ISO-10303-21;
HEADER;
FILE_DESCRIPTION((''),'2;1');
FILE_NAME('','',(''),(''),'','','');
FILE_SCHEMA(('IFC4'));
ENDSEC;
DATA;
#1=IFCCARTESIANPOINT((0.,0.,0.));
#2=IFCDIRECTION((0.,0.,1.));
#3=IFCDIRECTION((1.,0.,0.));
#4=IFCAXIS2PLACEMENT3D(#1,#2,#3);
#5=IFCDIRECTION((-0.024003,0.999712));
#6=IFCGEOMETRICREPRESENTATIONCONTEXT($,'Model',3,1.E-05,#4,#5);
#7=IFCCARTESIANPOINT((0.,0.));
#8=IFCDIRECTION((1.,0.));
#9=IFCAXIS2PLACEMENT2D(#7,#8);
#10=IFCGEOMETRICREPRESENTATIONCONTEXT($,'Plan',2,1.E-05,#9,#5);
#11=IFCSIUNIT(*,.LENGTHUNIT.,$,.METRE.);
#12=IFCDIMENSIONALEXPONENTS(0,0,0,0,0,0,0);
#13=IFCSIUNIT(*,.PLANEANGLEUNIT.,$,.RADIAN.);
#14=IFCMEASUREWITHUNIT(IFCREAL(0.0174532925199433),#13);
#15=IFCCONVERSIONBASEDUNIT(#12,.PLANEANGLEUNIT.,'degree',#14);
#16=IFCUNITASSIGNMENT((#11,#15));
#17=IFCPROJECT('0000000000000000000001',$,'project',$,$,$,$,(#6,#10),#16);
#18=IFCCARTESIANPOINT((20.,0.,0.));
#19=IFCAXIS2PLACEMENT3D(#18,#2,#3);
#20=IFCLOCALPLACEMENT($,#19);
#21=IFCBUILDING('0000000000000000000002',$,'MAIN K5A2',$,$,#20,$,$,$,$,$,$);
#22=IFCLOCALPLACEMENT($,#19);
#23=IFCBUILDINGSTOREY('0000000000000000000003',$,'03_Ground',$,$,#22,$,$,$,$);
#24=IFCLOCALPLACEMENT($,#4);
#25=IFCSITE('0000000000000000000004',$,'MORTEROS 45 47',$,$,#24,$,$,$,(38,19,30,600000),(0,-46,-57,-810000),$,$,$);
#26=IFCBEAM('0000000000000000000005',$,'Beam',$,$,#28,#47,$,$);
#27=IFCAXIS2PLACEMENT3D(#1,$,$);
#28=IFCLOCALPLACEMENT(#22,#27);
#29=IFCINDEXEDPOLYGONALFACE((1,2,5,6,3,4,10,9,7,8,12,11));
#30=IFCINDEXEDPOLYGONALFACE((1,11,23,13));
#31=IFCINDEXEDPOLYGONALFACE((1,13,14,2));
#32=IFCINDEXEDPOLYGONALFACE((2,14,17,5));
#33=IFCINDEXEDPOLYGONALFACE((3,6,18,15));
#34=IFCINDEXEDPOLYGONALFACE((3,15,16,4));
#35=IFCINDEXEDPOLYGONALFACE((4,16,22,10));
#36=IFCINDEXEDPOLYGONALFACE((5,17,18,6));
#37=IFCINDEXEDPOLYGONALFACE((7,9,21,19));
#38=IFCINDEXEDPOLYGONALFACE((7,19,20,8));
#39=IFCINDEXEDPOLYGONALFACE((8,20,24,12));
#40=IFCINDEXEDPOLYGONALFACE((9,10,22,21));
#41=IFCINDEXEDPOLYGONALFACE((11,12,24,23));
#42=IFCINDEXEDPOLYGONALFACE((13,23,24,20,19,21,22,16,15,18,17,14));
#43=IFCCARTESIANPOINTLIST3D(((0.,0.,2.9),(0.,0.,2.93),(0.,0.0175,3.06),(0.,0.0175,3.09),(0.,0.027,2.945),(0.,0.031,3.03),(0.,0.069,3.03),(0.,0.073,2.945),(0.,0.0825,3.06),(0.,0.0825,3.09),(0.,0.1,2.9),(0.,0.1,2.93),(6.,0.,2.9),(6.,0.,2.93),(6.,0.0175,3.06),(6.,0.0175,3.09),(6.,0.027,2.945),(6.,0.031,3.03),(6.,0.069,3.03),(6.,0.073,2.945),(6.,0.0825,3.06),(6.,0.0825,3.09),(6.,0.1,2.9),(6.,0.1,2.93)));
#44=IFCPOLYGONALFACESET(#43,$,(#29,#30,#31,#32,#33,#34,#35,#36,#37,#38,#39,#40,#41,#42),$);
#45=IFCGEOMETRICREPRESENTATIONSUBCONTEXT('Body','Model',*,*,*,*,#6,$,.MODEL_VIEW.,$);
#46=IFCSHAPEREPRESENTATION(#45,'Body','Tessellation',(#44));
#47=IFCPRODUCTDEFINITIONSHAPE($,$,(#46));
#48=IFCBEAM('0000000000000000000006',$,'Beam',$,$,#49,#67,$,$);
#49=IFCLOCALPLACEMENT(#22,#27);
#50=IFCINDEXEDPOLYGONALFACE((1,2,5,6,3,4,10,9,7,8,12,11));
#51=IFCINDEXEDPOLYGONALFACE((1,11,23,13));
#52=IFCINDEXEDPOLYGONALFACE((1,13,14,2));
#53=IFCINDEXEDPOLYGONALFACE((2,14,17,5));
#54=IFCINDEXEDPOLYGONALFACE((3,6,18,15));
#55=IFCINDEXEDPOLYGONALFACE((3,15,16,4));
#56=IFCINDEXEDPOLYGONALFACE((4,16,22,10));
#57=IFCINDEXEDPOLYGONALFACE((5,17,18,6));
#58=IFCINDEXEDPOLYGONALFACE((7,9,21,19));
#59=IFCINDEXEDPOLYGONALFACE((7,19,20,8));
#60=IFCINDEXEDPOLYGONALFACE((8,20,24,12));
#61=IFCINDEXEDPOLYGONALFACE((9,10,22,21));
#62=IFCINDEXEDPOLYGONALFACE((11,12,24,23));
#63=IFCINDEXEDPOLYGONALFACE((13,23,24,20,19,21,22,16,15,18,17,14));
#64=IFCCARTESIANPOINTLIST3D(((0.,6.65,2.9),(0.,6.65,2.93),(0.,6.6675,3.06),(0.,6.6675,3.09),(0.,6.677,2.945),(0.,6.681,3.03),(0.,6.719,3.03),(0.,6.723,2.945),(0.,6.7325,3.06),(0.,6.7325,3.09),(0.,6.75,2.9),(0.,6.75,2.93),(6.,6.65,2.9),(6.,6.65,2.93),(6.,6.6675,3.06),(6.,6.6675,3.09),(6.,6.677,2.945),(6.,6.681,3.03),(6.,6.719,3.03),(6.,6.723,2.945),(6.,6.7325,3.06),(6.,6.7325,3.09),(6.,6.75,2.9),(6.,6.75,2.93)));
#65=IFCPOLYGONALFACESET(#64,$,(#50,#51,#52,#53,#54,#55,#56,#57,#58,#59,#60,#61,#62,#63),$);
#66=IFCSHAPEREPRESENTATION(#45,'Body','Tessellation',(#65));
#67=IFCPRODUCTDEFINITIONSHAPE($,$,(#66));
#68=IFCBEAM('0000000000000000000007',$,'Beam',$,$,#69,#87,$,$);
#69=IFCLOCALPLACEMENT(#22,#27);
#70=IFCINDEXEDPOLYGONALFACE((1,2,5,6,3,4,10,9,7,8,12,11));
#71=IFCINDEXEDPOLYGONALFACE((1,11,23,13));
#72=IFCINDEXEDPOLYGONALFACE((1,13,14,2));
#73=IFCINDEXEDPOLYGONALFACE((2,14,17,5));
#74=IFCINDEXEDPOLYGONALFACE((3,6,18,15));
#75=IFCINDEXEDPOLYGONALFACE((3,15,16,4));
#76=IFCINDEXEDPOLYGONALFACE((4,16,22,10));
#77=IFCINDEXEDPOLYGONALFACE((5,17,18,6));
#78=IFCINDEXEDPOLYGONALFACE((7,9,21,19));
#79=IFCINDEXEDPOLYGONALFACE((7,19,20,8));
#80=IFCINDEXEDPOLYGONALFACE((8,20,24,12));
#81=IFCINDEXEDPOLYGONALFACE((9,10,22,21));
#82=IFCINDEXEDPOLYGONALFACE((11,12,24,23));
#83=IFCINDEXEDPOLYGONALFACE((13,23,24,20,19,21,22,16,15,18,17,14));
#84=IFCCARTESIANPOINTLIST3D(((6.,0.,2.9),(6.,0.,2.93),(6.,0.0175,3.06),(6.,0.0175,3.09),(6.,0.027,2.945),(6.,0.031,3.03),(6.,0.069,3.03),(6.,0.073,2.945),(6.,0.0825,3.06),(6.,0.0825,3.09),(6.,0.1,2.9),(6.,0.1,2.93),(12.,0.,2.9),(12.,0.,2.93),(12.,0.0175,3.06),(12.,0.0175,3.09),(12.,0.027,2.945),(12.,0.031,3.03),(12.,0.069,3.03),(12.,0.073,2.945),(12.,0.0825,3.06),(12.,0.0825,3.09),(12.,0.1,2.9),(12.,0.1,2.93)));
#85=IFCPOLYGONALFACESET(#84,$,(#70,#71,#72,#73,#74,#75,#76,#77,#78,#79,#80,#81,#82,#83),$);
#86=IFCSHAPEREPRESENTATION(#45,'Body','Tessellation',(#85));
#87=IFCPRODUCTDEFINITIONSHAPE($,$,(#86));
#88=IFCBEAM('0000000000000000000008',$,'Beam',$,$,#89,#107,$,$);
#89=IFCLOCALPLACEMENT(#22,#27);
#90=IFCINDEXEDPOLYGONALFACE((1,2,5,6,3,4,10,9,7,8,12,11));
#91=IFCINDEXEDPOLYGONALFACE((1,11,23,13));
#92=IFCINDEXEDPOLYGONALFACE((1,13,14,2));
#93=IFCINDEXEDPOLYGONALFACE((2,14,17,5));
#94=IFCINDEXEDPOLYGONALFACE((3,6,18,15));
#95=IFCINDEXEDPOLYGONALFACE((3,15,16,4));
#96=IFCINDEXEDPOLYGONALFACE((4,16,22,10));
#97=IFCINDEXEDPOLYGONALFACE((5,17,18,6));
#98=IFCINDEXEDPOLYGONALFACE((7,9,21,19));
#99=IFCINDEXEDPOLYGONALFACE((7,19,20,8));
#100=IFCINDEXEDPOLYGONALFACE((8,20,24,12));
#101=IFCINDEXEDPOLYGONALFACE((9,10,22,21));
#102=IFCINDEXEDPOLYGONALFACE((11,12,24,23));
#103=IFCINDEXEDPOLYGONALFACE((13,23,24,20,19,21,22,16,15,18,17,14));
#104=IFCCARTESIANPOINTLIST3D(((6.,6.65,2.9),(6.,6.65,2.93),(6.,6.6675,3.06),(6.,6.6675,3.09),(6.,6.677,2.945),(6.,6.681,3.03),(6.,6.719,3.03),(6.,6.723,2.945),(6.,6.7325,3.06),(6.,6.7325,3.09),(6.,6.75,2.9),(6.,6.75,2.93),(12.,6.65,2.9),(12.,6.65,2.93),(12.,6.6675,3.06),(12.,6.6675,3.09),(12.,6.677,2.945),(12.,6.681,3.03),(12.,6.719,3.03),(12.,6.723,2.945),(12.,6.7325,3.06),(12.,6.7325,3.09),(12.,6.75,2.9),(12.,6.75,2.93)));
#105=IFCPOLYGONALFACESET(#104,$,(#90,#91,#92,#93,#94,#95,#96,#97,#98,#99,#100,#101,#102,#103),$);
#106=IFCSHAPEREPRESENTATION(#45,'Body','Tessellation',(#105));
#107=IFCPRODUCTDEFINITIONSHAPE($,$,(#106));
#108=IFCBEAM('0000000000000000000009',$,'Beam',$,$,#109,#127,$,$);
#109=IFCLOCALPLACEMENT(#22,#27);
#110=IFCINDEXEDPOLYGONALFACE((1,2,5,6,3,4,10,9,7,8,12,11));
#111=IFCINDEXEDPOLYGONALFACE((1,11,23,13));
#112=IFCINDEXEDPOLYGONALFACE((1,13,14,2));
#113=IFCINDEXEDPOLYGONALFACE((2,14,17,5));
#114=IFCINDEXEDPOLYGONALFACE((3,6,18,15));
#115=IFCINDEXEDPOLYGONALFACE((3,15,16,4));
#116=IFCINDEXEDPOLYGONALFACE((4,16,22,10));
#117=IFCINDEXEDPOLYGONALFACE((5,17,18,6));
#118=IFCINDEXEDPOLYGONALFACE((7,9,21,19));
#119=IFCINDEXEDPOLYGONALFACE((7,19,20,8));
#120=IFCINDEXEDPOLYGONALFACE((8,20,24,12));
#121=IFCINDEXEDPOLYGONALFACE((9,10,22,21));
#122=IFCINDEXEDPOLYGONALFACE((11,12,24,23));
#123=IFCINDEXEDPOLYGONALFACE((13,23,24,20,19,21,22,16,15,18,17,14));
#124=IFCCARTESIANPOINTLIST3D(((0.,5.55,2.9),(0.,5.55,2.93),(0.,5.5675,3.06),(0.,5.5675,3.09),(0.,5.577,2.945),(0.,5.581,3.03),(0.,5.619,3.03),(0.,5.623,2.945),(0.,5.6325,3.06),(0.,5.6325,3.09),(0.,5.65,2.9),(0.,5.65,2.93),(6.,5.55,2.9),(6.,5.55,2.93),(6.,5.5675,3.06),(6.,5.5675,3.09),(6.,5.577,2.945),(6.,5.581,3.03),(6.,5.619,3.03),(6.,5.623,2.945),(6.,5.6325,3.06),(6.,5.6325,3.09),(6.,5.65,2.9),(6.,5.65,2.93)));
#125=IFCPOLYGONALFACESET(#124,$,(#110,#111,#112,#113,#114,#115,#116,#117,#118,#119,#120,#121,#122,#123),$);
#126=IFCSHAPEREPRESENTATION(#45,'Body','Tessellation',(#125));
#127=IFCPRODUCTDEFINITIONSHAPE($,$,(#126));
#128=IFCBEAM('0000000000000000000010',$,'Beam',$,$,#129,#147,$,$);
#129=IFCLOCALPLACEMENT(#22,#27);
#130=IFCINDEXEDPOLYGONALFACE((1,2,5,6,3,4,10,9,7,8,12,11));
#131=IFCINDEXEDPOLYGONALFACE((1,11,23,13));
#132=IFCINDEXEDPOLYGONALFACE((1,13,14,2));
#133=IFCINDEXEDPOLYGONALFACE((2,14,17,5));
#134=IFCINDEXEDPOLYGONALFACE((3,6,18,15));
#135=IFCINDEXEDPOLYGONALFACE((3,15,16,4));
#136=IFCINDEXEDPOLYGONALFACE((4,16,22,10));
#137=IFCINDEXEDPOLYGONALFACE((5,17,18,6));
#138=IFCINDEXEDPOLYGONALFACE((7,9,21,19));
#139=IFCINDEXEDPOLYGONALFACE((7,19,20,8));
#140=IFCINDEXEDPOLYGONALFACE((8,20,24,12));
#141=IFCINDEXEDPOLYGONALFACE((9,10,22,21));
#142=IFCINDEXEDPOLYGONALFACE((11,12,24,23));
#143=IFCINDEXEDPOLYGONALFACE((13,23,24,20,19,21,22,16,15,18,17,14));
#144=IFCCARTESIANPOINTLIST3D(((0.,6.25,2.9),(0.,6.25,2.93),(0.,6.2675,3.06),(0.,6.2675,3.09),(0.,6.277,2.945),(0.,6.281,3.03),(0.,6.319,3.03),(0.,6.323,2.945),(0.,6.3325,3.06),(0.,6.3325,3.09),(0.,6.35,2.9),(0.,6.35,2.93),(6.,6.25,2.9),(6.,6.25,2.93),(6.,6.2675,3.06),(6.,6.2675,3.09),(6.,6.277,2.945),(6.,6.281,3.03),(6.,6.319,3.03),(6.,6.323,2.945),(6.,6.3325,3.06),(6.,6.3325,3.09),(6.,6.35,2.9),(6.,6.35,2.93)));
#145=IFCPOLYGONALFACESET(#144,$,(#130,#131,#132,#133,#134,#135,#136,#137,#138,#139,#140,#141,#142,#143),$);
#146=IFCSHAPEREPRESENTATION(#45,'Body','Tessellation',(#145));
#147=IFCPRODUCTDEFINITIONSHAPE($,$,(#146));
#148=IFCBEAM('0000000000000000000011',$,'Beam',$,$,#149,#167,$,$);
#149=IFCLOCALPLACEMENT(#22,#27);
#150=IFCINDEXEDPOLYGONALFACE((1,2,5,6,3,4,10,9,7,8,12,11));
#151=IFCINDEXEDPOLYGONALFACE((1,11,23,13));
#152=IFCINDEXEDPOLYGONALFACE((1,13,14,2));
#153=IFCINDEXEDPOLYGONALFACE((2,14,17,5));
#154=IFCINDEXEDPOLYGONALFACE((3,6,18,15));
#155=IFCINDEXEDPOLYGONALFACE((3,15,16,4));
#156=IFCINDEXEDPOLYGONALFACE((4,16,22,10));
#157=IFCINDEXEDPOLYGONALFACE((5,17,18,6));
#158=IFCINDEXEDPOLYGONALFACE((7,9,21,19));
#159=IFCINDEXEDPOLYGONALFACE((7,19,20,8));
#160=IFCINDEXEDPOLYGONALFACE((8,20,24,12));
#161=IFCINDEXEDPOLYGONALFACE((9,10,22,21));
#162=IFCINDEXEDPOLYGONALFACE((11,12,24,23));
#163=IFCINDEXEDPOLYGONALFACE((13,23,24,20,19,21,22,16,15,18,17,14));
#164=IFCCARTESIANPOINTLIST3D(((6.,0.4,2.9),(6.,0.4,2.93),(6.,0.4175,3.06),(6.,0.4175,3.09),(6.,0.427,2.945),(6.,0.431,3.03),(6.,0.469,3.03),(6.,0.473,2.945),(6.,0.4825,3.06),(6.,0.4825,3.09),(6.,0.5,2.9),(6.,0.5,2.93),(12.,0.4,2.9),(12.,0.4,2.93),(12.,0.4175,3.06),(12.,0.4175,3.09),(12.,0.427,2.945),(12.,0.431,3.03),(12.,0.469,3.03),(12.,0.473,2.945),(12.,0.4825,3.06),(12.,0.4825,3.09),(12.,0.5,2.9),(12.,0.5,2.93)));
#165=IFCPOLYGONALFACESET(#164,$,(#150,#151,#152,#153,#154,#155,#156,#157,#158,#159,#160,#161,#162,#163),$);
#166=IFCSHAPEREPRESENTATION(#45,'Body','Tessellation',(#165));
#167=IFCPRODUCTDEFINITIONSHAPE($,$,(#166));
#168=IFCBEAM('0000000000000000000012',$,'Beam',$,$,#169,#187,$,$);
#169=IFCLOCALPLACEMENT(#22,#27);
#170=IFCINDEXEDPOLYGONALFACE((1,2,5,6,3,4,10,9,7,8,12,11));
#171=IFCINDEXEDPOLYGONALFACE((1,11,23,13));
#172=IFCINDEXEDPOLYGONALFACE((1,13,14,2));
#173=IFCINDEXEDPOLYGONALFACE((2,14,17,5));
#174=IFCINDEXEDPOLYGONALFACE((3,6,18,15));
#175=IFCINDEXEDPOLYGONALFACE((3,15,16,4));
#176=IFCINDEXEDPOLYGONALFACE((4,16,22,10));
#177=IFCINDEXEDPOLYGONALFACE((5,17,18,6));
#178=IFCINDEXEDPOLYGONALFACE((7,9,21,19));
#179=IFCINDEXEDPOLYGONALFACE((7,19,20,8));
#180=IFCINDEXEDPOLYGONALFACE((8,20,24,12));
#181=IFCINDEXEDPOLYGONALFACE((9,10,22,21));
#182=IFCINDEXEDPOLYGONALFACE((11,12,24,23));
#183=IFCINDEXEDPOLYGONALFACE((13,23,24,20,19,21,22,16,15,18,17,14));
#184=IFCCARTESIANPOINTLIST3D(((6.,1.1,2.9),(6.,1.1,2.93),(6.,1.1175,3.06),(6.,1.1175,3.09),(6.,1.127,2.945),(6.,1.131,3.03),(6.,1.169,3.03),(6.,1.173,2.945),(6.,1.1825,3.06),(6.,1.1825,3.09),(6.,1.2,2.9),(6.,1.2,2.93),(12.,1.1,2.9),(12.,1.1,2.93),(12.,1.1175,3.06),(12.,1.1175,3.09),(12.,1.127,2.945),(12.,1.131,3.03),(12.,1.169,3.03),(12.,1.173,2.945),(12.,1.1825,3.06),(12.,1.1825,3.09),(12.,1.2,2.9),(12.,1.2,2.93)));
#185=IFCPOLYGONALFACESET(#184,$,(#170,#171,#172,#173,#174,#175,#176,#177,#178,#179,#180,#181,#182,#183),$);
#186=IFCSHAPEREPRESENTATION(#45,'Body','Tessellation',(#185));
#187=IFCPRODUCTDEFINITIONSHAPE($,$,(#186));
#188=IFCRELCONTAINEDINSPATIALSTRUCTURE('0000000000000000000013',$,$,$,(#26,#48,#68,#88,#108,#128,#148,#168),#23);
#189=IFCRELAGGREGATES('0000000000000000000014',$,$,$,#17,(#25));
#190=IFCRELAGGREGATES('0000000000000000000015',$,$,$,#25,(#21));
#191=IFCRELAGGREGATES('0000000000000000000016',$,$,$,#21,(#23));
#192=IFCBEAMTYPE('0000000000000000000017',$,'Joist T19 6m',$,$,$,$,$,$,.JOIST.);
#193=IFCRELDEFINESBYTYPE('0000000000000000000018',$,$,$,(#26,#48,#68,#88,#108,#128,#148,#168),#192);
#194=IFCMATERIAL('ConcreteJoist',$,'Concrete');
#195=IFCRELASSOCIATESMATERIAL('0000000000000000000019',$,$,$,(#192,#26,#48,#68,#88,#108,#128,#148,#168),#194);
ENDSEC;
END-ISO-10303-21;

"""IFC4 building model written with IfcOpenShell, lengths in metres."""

from ifc_helpers import new_model, entity, si_unit, converted_unit, direction, frame, origin_with_axes, origin_2d_with_axis, place, context, subcontext, project, spatial, indexed_curve, outline, extrude, material, material_profile, profile_set, profile_usage, type_object, element, save


model = new_model("IFC4")

# Units and contexts
model_context = context("Model", 3, precision=1e-05, world=origin_with_axes(), true_north=direction((-0.024003, 0.999712)))
plan_context = context("Plan", 2, precision=1e-05, world=origin_2d_with_axis(), true_north=direction((-0.024003, 0.999712)))
body_context_1 = subcontext(model_context, "Body", "Model", "MODEL_VIEW")
ifc_project = project(units=[si_unit("LENGTHUNIT", "METRE"), converted_unit("PLANEANGLEUNIT", "degree", entity("IfcReal", 0.0174532925199433), si_unit("PLANEANGLEUNIT", "RADIAN"), dimensions=[0, 0, 0, 0, 0, 0, 0])], contexts=[model_context, plan_context])

# Site, building, storey
site_placement = place(None, origin_with_axes())
site = spatial("IfcSite", under=ifc_project, at=site_placement, Name="MORTEROS 45 47", RefLatitude=(38, 19, 30, 600000), RefLongitude=(0, -46, -57, -810000))
building_placement = place(None, frame((20.0, 0.0, 0.0), z_axis=(0.0, 0.0, 1.0), x_axis=(1.0, 0.0, 0.0)))
building = spatial("IfcBuilding", under=site, at=building_placement, Name="MAIN K5A2")
storey_placement = place(None, frame((20.0, 0.0, 0.0), z_axis=(0.0, 0.0, 1.0), x_axis=(1.0, 0.0, 0.0)))
storey = spatial("IfcBuildingStorey", under=building, at=storey_placement, Name="03_Ground")

# Beams
ifc_material = material(Name="ConcreteJoist", Category="Concrete")
ifc_material_profile = material_profile(ifc_material, outline(indexed_curve([(0.019, 0.13), (0.023, 0.045), (0.05, 0.03), (0.05, 0.0), (-0.05, 0.0), (-0.05, 0.03), (-0.023, 0.045), (-0.019, 0.13), (-0.0325, 0.16), (-0.0325, 0.19), (0.0325, 0.19), (0.0325, 0.16), (0.019, 0.13)])))
ifc_profile_set = profile_set([ifc_material_profile], Name="JoistmaterialProfile")
beam_type = type_object("IfcBeamType", Name="Joist T19 6m", PredefinedType="JOIST", material=ifc_profile_set)
ifc_profile_usage_1 = profile_usage(ifc_profile_set)
beam_1_placement = place(None, frame((20.0, 0.05, 2.9), z_axis=(1.0, 0.0, 0.0), x_axis=(0.0, 1.0, 0.0)))
element("IfcBeam", 1, at=beam_1_placement, inside=storey, type_object=beam_type, material=ifc_profile_usage_1, Name="Beam", context=body_context_1, shape_type="SweptSolid", body=[
    extrude(outline(indexed_curve([(0.019, 0.13), (0.023, 0.045), (0.05, 0.03), (0.05, 0.0), (-0.05, 0.0), (-0.05, 0.03), (-0.023, 0.045), (-0.019, 0.13), (-0.0325, 0.16), (-0.0325, 0.19), (0.0325, 0.19), (0.0325, 0.16), (0.019, 0.13)])), origin_with_axes(), (0.0, 0.0, 1.0), 6.0),
])
ifc_profile_usage_2 = profile_usage(ifc_profile_set)
beam_2_placement = place(None, frame((20.0, 6.7, 2.9), z_axis=(1.0, 0.0, 0.0), x_axis=(0.0, 1.0, 0.0)))
element("IfcBeam", 2, at=beam_2_placement, inside=storey, type_object=beam_type, material=ifc_profile_usage_2, Name="Beam", context=body_context_1, shape_type="SweptSolid", body=[
    extrude(outline(indexed_curve([(0.019, 0.13), (0.023, 0.045), (0.05, 0.03), (0.05, 0.0), (-0.05, 0.0), (-0.05, 0.03), (-0.023, 0.045), (-0.019, 0.13), (-0.0325, 0.16), (-0.0325, 0.19), (0.0325, 0.19), (0.0325, 0.16), (0.019, 0.13)])), origin_with_axes(), (0.0, 0.0, 1.0), 6.0),
])
ifc_profile_usage_3 = profile_usage(ifc_profile_set)
beam_3_placement = place(None, frame((26.0, 0.05, 2.9), z_axis=(1.0, 0.0, 0.0), x_axis=(0.0, 1.0, 0.0)))
element("IfcBeam", 3, at=beam_3_placement, inside=storey, type_object=beam_type, material=ifc_profile_usage_3, Name="Beam", context=body_context_1, shape_type="SweptSolid", body=[
    extrude(outline(indexed_curve([(0.019, 0.13), (0.023, 0.045), (0.05, 0.03), (0.05, 0.0), (-0.05, 0.0), (-0.05, 0.03), (-0.023, 0.045), (-0.019, 0.13), (-0.0325, 0.16), (-0.0325, 0.19), (0.0325, 0.19), (0.0325, 0.16), (0.019, 0.13)])), origin_with_axes(), (0.0, 0.0, 1.0), 6.0),
])
ifc_profile_usage_4 = profile_usage(ifc_profile_set)
beam_4_placement = place(None, frame((26.0, 6.7, 2.9), z_axis=(1.0, 0.0, 0.0), x_axis=(0.0, 1.0, 0.0)))
element("IfcBeam", 4, at=beam_4_placement, inside=storey, type_object=beam_type, material=ifc_profile_usage_4, Name="Beam", context=body_context_1, shape_type="SweptSolid", body=[
    extrude(outline(indexed_curve([(0.019, 0.13), (0.023, 0.045), (0.05, 0.03), (0.05, 0.0), (-0.05, 0.0), (-0.05, 0.03), (-0.023, 0.045), (-0.019, 0.13), (-0.0325, 0.16), (-0.0325, 0.19), (0.0325, 0.19), (0.0325, 0.16), (0.019, 0.13)])), origin_with_axes(), (0.0, 0.0, 1.0), 6.0),
])
ifc_profile_usage_5 = profile_usage(ifc_profile_set)
beam_5_placement = place(None, frame((20.0, 5.6, 2.9), z_axis=(1.0, 0.0, 0.0), x_axis=(0.0, 1.0, 0.0)))
element("IfcBeam", 5, at=beam_5_placement, inside=storey, type_object=beam_type, material=ifc_profile_usage_5, Name="Beam", context=body_context_1, shape_type="SweptSolid", body=[
    extrude(outline(indexed_curve([(0.019, 0.13), (0.023, 0.045), (0.05, 0.03), (0.05, 0.0), (-0.05, 0.0), (-0.05, 0.03), (-0.023, 0.045), (-0.019, 0.13), (-0.0325, 0.16), (-0.0325, 0.19), (0.0325, 0.19), (0.0325, 0.16), (0.019, 0.13)])), origin_with_axes(), (0.0, 0.0, 1.0), 6.0),
])
ifc_profile_usage_6 = profile_usage(ifc_profile_set)
beam_6_placement = place(None, frame((20.0, 6.3, 2.9), z_axis=(1.0, 0.0, 0.0), x_axis=(0.0, 1.0, 0.0)))
element("IfcBeam", 6, at=beam_6_placement, inside=storey, type_object=beam_type, material=ifc_profile_usage_6, Name="Beam", context=body_context_1, shape_type="SweptSolid", body=[
    extrude(outline(indexed_curve([(0.019, 0.13), (0.023, 0.045), (0.05, 0.03), (0.05, 0.0), (-0.05, 0.0), (-0.05, 0.03), (-0.023, 0.045), (-0.019, 0.13), (-0.0325, 0.16), (-0.0325, 0.19), (0.0325, 0.19), (0.0325, 0.16), (0.019, 0.13)])), origin_with_axes(), (0.0, 0.0, 1.0), 6.0),
])
ifc_profile_usage_7 = profile_usage(ifc_profile_set)
beam_7_placement = place(None, frame((26.0, 0.45, 2.9), z_axis=(1.0, 0.0, 0.0), x_axis=(0.0, 1.0, 0.0)))
element("IfcBeam", 7, at=beam_7_placement, inside=storey, type_object=beam_type, material=ifc_profile_usage_7, Name="Beam", context=body_context_1, shape_type="SweptSolid", body=[
    extrude(outline(indexed_curve([(0.019, 0.13), (0.023, 0.045), (0.05, 0.03), (0.05, 0.0), (-0.05, 0.0), (-0.05, 0.03), (-0.023, 0.045), (-0.019, 0.13), (-0.0325, 0.16), (-0.0325, 0.19), (0.0325, 0.19), (0.0325, 0.16), (0.019, 0.13)])), origin_with_axes(), (0.0, 0.0, 1.0), 6.0),
])
ifc_profile_usage_8 = profile_usage(ifc_profile_set)
beam_8_placement = place(None, frame((26.0, 1.15, 2.9), z_axis=(1.0, 0.0, 0.0), x_axis=(0.0, 1.0, 0.0)))
element("IfcBeam", 8, at=beam_8_placement, inside=storey, type_object=beam_type, material=ifc_profile_usage_8, Name="Beam", context=body_context_1, shape_type="SweptSolid", body=[
    extrude(outline(indexed_curve([(0.019, 0.13), (0.023, 0.045), (0.05, 0.03), (0.05, 0.0), (-0.05, 0.0), (-0.05, 0.03), (-0.023, 0.045), (-0.019, 0.13), (-0.0325, 0.16), (-0.0325, 0.19), (0.0325, 0.19), (0.0325, 0.16), (0.019, 0.13)])), origin_with_axes(), (0.0, 0.0, 1.0), 6.0),
])

save(model, "model.ifc")
